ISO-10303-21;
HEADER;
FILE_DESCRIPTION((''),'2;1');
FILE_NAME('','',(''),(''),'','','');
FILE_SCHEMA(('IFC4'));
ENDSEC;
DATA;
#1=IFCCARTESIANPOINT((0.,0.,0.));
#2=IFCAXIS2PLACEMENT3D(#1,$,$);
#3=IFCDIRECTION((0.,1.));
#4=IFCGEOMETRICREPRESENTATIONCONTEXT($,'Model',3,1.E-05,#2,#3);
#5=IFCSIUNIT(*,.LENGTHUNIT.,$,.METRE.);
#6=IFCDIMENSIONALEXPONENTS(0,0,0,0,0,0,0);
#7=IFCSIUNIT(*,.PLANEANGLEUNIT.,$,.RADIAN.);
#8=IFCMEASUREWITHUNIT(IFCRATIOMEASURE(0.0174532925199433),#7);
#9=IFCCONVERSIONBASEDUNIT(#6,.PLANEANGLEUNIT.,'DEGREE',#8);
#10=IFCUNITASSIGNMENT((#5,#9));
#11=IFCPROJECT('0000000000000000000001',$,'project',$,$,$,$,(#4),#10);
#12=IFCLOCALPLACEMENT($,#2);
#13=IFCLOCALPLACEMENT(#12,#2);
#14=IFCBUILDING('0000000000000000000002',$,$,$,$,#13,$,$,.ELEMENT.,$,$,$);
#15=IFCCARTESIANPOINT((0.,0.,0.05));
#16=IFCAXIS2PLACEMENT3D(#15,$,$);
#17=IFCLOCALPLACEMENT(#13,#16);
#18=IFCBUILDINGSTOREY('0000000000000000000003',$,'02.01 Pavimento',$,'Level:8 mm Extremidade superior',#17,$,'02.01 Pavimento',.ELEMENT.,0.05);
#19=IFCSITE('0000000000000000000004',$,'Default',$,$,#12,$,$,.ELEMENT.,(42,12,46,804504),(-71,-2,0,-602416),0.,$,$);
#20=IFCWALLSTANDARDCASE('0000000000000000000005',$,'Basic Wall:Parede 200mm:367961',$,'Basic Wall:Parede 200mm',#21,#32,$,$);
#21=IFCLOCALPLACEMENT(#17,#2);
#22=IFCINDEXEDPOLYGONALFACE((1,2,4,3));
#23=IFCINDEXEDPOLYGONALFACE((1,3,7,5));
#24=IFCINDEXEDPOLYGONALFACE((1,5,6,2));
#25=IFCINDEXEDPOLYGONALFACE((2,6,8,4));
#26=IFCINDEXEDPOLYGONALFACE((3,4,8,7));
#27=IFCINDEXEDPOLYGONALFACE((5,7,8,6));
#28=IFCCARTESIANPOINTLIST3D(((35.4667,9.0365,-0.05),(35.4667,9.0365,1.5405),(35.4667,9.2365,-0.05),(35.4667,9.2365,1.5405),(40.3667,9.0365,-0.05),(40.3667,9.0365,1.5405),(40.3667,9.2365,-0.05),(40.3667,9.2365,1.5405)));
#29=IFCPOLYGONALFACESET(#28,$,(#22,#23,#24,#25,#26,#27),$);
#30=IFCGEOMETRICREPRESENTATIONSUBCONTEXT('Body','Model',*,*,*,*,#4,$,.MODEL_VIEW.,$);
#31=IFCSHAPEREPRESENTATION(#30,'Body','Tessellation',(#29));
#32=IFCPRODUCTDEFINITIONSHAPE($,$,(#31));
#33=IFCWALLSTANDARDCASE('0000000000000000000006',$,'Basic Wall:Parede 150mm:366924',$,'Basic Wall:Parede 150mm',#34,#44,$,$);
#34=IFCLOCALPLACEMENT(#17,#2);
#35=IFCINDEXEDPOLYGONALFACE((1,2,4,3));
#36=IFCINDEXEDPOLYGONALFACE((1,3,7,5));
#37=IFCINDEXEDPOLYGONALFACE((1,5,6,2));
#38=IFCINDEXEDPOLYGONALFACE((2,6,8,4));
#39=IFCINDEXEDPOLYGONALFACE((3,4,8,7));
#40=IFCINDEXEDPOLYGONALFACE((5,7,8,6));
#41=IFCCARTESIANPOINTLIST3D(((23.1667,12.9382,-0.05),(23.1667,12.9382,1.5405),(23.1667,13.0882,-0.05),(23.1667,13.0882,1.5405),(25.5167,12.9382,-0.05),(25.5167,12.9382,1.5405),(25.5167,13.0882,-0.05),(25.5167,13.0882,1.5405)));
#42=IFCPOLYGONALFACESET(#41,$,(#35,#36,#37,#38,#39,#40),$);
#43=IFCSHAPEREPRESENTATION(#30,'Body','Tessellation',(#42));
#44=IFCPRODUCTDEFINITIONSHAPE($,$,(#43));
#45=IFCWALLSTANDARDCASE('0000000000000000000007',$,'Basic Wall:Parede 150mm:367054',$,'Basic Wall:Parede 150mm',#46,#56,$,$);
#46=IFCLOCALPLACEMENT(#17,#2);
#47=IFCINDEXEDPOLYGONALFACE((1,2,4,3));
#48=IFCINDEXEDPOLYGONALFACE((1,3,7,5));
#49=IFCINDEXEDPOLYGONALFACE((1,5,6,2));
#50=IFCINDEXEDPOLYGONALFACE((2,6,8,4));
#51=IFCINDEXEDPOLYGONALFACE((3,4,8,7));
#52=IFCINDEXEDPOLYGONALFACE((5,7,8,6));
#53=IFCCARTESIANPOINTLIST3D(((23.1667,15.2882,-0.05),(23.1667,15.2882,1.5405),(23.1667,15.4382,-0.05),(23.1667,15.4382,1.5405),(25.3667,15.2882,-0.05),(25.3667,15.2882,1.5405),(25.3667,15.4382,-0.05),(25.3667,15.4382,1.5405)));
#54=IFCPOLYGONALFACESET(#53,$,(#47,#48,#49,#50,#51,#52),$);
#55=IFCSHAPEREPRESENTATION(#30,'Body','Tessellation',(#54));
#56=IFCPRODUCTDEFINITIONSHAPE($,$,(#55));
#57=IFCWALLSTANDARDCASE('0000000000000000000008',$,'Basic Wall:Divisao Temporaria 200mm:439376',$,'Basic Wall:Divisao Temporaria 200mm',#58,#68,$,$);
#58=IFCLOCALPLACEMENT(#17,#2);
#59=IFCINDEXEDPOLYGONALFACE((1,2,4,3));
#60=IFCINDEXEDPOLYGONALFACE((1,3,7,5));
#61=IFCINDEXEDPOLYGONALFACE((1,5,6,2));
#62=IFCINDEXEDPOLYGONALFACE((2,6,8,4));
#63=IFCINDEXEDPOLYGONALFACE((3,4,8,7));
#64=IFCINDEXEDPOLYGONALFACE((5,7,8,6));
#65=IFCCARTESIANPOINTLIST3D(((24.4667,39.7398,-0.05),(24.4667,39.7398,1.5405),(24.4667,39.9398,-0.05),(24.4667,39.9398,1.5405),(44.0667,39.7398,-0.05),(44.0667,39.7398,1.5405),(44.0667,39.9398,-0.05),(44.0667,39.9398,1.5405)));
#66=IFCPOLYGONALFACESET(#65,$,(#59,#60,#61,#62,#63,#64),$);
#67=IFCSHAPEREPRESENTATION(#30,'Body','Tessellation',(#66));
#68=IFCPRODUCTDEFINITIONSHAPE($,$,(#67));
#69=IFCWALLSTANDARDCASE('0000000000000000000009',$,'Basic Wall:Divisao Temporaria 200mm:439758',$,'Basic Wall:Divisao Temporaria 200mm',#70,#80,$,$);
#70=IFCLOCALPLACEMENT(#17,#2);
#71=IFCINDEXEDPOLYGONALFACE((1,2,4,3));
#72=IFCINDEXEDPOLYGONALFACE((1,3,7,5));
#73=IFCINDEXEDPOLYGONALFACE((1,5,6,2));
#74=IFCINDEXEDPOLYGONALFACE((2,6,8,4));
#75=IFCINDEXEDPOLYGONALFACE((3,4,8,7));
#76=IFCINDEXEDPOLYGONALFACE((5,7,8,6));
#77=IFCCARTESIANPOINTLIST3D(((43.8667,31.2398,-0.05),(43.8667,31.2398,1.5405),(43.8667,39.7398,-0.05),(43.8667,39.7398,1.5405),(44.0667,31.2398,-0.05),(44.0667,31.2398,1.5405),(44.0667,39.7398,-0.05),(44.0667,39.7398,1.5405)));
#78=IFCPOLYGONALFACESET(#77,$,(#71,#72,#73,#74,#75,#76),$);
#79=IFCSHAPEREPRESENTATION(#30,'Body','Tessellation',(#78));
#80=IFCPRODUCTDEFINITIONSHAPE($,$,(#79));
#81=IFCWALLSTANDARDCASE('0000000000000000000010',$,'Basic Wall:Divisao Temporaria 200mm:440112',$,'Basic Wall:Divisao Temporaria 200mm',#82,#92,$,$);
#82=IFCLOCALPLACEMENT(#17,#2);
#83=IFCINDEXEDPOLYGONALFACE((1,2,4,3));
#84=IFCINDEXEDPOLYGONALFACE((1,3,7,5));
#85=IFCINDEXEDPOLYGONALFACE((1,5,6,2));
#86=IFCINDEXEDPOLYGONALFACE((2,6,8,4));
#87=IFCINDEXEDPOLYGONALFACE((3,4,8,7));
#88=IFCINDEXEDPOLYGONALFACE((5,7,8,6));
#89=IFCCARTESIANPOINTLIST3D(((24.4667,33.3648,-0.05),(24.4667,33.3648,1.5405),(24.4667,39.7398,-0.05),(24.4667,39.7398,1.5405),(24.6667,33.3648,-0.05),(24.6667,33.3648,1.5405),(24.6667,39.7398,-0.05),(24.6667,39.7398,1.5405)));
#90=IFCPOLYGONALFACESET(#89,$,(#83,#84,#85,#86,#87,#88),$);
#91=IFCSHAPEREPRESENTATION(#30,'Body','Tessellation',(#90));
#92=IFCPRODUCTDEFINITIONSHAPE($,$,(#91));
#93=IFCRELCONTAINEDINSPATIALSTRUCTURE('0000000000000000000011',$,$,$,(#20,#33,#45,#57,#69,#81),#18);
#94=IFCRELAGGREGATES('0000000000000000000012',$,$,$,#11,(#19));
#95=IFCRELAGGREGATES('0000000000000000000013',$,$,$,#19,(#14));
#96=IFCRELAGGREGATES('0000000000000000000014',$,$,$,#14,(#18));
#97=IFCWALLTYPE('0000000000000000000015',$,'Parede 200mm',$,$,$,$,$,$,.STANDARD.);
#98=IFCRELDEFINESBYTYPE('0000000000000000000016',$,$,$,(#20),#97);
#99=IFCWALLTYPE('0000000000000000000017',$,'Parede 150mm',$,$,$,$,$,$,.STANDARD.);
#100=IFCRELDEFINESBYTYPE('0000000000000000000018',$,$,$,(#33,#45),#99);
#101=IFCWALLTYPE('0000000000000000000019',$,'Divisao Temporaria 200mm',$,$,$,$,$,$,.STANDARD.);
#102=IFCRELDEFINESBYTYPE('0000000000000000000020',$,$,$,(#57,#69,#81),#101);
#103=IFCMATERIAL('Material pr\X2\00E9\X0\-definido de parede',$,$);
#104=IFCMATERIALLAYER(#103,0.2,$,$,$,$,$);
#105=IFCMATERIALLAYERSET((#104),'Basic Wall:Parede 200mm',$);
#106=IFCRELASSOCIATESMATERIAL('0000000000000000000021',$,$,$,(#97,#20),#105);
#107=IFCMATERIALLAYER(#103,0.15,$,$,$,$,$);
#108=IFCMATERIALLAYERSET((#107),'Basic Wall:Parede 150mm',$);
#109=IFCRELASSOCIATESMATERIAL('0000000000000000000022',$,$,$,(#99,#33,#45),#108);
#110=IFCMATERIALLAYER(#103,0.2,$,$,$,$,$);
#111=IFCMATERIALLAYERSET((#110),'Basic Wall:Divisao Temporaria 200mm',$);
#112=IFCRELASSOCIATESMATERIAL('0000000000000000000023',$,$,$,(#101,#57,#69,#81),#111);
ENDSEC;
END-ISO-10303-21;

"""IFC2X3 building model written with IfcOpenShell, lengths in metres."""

from ifc_helpers import new_model, entity, si_unit, converted_unit, direction, frame, frame_2d, origin, place, context, subcontext, project, spatial, rectangle, extrude, clip, halfspace, material, layer, layer_set, layer_usage, type_object, element, save


model = new_model("IFC2X3")

# Units and contexts
model_context = context("Model", 3, precision=1e-05, world=origin(), true_north=direction((0.0, 1.0)))
body_context = subcontext(model_context, "Body", "Model", "MODEL_VIEW")
ifc_project = project(units=[si_unit("LENGTHUNIT", "METRE"), converted_unit("PLANEANGLEUNIT", "DEGREE", entity("IfcRatioMeasure", 0.0174532925199433), si_unit("PLANEANGLEUNIT", "RADIAN"), dimensions=[0, 0, 0, 0, 0, 0, 0])], contexts=[model_context])

# Site, building, storey
site_placement = place(None, origin())
site = spatial("IfcSite", under=ifc_project, at=site_placement, Name="Default", CompositionType="ELEMENT", RefLatitude=(42, 12, 46, 804504), RefLongitude=(-71, -2, 0, -602416), RefElevation=0.0)
building_placement = place(site_placement, origin())
building = spatial("IfcBuilding", under=site, at=building_placement, CompositionType="ELEMENT")
storey_placement = place(building_placement, frame((0.0, 0.0, 0.05)))
storey = spatial("IfcBuildingStorey", under=building, at=storey_placement, Name="02.01 Pavimento", ObjectType="Level:8 mm Extremidade superior", LongName="02.01 Pavimento", CompositionType="ELEMENT", Elevation=0.05)

# Shared definitions
ifc_material = material(Name="Material pré-definido de parede")

# Wall
ifc_layer_1 = layer(ifc_material, 0.2)
ifc_layer_set_1 = layer_set([ifc_layer_1], Name="Basic Wall:Parede 200mm")
ifc_layer_usage_1 = layer_usage(ifc_layer_set_1, "AXIS2", "NEGATIVE", 0.1)
wall_type_1 = type_object("IfcWallType", Name="Parede 200mm", PredefinedType="STANDARD", material=ifc_layer_set_1)
wall_1_placement = place(storey_placement, frame((35.4667, 9.1365, -0.05)))
element("IfcWallStandardCase", 1, at=wall_1_placement, inside=storey, type_object=wall_type_1, material=ifc_layer_usage_1, Name="Basic Wall:Parede 200mm:367961", ObjectType="Basic Wall:Parede 200mm", context=body_context, shape_type="Clipping", body=[
    clip(extrude(rectangle(XDim=4.9, YDim=0.2, at=frame_2d((2.45, 0.0), x_axis=(-1.0, 0.0))), origin(), (0.0, 0.0, 1.0), 1.5905), halfspace(frame((0.0, 0.0, -0.05)), True)),
])

# Shared definitions
ifc_layer_2 = layer(ifc_material, 0.15)
ifc_layer_set_2 = layer_set([ifc_layer_2], Name="Basic Wall:Parede 150mm")
wall_type_2 = type_object("IfcWallType", Name="Parede 150mm", PredefinedType="STANDARD", material=ifc_layer_set_2)

# Wall
ifc_layer_usage_2 = layer_usage(ifc_layer_set_2, "AXIS2", "POSITIVE", -0.075)
wall_2_placement = place(storey_placement, frame((23.1667, 13.0132, -0.05)))
element("IfcWallStandardCase", 2, at=wall_2_placement, inside=storey, type_object=wall_type_2, material=ifc_layer_usage_2, Name="Basic Wall:Parede 150mm:366924", ObjectType="Basic Wall:Parede 150mm", context=body_context, shape_type="Clipping", body=[
    clip(extrude(rectangle(XDim=2.35, YDim=0.15, at=frame_2d((1.175, 0.0), x_axis=(-1.0, 0.0))), origin(), (0.0, 0.0, 1.0), 1.5905), halfspace(frame((0.0, 0.0, -0.05)), True)),
])

# Walls
ifc_layer_usage_3 = layer_usage(ifc_layer_set_2, "AXIS2", "POSITIVE", -0.075)
wall_3_placement = place(storey_placement, frame((25.3667, 15.3632, -0.05), z_axis=(0.0, 0.0, 1.0), x_axis=(-1.0, 0.0, 0.0)))
element("IfcWallStandardCase", 3, at=wall_3_placement, inside=storey, type_object=wall_type_2, material=ifc_layer_usage_3, Name="Basic Wall:Parede 150mm:367054", ObjectType="Basic Wall:Parede 150mm", context=body_context, shape_type="Clipping", body=[
    clip(extrude(rectangle(XDim=2.2, YDim=0.15, at=frame_2d((1.1, 0.0), x_axis=(-1.0, 0.0))), origin(), (0.0, 0.0, 1.0), 1.5905), halfspace(frame((0.0, 0.0, -0.05)), True)),
])
ifc_layer_3 = layer(ifc_material, 0.2)
ifc_layer_set_3 = layer_set([ifc_layer_3], Name="Basic Wall:Divisao Temporaria 200mm")
ifc_layer_usage_4 = layer_usage(ifc_layer_set_3, "AXIS2", "NEGATIVE", 0.1)
wall_type_3 = type_object("IfcWallType", Name="Divisao Temporaria 200mm", PredefinedType="STANDARD", material=ifc_layer_set_3)
wall_4_placement = place(storey_placement, frame((24.4667, 39.8398, -0.05)))
element("IfcWallStandardCase", 4, at=wall_4_placement, inside=storey, type_object=wall_type_3, material=ifc_layer_usage_4, Name="Basic Wall:Divisao Temporaria 200mm:439376", ObjectType="Basic Wall:Divisao Temporaria 200mm", context=body_context, shape_type="Clipping", body=[
    clip(extrude(rectangle(XDim=19.6, YDim=0.2, at=frame_2d((9.8, 0.0), x_axis=(-1.0, 0.0))), origin(), (0.0, 0.0, 1.0), 1.5905), halfspace(frame((0.0, 0.0, -0.05)), True)),
])
ifc_layer_usage_5 = layer_usage(ifc_layer_set_3, "AXIS2", "POSITIVE", -0.1)
wall_5_placement = place(storey_placement, frame((43.9667, 31.2398, -0.05), z_axis=(0.0, 0.0, 1.0), x_axis=(0.0, 1.0, 0.0)))
element("IfcWallStandardCase", 5, at=wall_5_placement, inside=storey, type_object=wall_type_3, material=ifc_layer_usage_5, Name="Basic Wall:Divisao Temporaria 200mm:439758", ObjectType="Basic Wall:Divisao Temporaria 200mm", context=body_context, shape_type="Clipping", body=[
    clip(extrude(rectangle(XDim=8.5, YDim=0.2, at=frame_2d((4.25, 0.0), x_axis=(-1.0, 0.0))), origin(), (0.0, 0.0, 1.0), 1.5905), halfspace(frame((0.0, 0.0, -0.05)), True)),
])
ifc_layer_usage_6 = layer_usage(ifc_layer_set_3, "AXIS2", "POSITIVE", -0.1)
wall_6_placement = place(storey_placement, frame((24.5667, 33.3648, -0.05), z_axis=(0.0, 0.0, 1.0), x_axis=(0.0, 1.0, 0.0)))
element("IfcWallStandardCase", 6, at=wall_6_placement, inside=storey, type_object=wall_type_3, material=ifc_layer_usage_6, Name="Basic Wall:Divisao Temporaria 200mm:440112", ObjectType="Basic Wall:Divisao Temporaria 200mm", context=body_context, shape_type="Clipping", body=[
    clip(extrude(rectangle(XDim=6.375, YDim=0.2, at=frame_2d((3.1875, 0.0), x_axis=(-1.0, 0.0))), origin(), (0.0, 0.0, 1.0), 1.5905), halfspace(frame((0.0, 0.0, -0.05)), True)),
])

save(model, "model.ifc")
